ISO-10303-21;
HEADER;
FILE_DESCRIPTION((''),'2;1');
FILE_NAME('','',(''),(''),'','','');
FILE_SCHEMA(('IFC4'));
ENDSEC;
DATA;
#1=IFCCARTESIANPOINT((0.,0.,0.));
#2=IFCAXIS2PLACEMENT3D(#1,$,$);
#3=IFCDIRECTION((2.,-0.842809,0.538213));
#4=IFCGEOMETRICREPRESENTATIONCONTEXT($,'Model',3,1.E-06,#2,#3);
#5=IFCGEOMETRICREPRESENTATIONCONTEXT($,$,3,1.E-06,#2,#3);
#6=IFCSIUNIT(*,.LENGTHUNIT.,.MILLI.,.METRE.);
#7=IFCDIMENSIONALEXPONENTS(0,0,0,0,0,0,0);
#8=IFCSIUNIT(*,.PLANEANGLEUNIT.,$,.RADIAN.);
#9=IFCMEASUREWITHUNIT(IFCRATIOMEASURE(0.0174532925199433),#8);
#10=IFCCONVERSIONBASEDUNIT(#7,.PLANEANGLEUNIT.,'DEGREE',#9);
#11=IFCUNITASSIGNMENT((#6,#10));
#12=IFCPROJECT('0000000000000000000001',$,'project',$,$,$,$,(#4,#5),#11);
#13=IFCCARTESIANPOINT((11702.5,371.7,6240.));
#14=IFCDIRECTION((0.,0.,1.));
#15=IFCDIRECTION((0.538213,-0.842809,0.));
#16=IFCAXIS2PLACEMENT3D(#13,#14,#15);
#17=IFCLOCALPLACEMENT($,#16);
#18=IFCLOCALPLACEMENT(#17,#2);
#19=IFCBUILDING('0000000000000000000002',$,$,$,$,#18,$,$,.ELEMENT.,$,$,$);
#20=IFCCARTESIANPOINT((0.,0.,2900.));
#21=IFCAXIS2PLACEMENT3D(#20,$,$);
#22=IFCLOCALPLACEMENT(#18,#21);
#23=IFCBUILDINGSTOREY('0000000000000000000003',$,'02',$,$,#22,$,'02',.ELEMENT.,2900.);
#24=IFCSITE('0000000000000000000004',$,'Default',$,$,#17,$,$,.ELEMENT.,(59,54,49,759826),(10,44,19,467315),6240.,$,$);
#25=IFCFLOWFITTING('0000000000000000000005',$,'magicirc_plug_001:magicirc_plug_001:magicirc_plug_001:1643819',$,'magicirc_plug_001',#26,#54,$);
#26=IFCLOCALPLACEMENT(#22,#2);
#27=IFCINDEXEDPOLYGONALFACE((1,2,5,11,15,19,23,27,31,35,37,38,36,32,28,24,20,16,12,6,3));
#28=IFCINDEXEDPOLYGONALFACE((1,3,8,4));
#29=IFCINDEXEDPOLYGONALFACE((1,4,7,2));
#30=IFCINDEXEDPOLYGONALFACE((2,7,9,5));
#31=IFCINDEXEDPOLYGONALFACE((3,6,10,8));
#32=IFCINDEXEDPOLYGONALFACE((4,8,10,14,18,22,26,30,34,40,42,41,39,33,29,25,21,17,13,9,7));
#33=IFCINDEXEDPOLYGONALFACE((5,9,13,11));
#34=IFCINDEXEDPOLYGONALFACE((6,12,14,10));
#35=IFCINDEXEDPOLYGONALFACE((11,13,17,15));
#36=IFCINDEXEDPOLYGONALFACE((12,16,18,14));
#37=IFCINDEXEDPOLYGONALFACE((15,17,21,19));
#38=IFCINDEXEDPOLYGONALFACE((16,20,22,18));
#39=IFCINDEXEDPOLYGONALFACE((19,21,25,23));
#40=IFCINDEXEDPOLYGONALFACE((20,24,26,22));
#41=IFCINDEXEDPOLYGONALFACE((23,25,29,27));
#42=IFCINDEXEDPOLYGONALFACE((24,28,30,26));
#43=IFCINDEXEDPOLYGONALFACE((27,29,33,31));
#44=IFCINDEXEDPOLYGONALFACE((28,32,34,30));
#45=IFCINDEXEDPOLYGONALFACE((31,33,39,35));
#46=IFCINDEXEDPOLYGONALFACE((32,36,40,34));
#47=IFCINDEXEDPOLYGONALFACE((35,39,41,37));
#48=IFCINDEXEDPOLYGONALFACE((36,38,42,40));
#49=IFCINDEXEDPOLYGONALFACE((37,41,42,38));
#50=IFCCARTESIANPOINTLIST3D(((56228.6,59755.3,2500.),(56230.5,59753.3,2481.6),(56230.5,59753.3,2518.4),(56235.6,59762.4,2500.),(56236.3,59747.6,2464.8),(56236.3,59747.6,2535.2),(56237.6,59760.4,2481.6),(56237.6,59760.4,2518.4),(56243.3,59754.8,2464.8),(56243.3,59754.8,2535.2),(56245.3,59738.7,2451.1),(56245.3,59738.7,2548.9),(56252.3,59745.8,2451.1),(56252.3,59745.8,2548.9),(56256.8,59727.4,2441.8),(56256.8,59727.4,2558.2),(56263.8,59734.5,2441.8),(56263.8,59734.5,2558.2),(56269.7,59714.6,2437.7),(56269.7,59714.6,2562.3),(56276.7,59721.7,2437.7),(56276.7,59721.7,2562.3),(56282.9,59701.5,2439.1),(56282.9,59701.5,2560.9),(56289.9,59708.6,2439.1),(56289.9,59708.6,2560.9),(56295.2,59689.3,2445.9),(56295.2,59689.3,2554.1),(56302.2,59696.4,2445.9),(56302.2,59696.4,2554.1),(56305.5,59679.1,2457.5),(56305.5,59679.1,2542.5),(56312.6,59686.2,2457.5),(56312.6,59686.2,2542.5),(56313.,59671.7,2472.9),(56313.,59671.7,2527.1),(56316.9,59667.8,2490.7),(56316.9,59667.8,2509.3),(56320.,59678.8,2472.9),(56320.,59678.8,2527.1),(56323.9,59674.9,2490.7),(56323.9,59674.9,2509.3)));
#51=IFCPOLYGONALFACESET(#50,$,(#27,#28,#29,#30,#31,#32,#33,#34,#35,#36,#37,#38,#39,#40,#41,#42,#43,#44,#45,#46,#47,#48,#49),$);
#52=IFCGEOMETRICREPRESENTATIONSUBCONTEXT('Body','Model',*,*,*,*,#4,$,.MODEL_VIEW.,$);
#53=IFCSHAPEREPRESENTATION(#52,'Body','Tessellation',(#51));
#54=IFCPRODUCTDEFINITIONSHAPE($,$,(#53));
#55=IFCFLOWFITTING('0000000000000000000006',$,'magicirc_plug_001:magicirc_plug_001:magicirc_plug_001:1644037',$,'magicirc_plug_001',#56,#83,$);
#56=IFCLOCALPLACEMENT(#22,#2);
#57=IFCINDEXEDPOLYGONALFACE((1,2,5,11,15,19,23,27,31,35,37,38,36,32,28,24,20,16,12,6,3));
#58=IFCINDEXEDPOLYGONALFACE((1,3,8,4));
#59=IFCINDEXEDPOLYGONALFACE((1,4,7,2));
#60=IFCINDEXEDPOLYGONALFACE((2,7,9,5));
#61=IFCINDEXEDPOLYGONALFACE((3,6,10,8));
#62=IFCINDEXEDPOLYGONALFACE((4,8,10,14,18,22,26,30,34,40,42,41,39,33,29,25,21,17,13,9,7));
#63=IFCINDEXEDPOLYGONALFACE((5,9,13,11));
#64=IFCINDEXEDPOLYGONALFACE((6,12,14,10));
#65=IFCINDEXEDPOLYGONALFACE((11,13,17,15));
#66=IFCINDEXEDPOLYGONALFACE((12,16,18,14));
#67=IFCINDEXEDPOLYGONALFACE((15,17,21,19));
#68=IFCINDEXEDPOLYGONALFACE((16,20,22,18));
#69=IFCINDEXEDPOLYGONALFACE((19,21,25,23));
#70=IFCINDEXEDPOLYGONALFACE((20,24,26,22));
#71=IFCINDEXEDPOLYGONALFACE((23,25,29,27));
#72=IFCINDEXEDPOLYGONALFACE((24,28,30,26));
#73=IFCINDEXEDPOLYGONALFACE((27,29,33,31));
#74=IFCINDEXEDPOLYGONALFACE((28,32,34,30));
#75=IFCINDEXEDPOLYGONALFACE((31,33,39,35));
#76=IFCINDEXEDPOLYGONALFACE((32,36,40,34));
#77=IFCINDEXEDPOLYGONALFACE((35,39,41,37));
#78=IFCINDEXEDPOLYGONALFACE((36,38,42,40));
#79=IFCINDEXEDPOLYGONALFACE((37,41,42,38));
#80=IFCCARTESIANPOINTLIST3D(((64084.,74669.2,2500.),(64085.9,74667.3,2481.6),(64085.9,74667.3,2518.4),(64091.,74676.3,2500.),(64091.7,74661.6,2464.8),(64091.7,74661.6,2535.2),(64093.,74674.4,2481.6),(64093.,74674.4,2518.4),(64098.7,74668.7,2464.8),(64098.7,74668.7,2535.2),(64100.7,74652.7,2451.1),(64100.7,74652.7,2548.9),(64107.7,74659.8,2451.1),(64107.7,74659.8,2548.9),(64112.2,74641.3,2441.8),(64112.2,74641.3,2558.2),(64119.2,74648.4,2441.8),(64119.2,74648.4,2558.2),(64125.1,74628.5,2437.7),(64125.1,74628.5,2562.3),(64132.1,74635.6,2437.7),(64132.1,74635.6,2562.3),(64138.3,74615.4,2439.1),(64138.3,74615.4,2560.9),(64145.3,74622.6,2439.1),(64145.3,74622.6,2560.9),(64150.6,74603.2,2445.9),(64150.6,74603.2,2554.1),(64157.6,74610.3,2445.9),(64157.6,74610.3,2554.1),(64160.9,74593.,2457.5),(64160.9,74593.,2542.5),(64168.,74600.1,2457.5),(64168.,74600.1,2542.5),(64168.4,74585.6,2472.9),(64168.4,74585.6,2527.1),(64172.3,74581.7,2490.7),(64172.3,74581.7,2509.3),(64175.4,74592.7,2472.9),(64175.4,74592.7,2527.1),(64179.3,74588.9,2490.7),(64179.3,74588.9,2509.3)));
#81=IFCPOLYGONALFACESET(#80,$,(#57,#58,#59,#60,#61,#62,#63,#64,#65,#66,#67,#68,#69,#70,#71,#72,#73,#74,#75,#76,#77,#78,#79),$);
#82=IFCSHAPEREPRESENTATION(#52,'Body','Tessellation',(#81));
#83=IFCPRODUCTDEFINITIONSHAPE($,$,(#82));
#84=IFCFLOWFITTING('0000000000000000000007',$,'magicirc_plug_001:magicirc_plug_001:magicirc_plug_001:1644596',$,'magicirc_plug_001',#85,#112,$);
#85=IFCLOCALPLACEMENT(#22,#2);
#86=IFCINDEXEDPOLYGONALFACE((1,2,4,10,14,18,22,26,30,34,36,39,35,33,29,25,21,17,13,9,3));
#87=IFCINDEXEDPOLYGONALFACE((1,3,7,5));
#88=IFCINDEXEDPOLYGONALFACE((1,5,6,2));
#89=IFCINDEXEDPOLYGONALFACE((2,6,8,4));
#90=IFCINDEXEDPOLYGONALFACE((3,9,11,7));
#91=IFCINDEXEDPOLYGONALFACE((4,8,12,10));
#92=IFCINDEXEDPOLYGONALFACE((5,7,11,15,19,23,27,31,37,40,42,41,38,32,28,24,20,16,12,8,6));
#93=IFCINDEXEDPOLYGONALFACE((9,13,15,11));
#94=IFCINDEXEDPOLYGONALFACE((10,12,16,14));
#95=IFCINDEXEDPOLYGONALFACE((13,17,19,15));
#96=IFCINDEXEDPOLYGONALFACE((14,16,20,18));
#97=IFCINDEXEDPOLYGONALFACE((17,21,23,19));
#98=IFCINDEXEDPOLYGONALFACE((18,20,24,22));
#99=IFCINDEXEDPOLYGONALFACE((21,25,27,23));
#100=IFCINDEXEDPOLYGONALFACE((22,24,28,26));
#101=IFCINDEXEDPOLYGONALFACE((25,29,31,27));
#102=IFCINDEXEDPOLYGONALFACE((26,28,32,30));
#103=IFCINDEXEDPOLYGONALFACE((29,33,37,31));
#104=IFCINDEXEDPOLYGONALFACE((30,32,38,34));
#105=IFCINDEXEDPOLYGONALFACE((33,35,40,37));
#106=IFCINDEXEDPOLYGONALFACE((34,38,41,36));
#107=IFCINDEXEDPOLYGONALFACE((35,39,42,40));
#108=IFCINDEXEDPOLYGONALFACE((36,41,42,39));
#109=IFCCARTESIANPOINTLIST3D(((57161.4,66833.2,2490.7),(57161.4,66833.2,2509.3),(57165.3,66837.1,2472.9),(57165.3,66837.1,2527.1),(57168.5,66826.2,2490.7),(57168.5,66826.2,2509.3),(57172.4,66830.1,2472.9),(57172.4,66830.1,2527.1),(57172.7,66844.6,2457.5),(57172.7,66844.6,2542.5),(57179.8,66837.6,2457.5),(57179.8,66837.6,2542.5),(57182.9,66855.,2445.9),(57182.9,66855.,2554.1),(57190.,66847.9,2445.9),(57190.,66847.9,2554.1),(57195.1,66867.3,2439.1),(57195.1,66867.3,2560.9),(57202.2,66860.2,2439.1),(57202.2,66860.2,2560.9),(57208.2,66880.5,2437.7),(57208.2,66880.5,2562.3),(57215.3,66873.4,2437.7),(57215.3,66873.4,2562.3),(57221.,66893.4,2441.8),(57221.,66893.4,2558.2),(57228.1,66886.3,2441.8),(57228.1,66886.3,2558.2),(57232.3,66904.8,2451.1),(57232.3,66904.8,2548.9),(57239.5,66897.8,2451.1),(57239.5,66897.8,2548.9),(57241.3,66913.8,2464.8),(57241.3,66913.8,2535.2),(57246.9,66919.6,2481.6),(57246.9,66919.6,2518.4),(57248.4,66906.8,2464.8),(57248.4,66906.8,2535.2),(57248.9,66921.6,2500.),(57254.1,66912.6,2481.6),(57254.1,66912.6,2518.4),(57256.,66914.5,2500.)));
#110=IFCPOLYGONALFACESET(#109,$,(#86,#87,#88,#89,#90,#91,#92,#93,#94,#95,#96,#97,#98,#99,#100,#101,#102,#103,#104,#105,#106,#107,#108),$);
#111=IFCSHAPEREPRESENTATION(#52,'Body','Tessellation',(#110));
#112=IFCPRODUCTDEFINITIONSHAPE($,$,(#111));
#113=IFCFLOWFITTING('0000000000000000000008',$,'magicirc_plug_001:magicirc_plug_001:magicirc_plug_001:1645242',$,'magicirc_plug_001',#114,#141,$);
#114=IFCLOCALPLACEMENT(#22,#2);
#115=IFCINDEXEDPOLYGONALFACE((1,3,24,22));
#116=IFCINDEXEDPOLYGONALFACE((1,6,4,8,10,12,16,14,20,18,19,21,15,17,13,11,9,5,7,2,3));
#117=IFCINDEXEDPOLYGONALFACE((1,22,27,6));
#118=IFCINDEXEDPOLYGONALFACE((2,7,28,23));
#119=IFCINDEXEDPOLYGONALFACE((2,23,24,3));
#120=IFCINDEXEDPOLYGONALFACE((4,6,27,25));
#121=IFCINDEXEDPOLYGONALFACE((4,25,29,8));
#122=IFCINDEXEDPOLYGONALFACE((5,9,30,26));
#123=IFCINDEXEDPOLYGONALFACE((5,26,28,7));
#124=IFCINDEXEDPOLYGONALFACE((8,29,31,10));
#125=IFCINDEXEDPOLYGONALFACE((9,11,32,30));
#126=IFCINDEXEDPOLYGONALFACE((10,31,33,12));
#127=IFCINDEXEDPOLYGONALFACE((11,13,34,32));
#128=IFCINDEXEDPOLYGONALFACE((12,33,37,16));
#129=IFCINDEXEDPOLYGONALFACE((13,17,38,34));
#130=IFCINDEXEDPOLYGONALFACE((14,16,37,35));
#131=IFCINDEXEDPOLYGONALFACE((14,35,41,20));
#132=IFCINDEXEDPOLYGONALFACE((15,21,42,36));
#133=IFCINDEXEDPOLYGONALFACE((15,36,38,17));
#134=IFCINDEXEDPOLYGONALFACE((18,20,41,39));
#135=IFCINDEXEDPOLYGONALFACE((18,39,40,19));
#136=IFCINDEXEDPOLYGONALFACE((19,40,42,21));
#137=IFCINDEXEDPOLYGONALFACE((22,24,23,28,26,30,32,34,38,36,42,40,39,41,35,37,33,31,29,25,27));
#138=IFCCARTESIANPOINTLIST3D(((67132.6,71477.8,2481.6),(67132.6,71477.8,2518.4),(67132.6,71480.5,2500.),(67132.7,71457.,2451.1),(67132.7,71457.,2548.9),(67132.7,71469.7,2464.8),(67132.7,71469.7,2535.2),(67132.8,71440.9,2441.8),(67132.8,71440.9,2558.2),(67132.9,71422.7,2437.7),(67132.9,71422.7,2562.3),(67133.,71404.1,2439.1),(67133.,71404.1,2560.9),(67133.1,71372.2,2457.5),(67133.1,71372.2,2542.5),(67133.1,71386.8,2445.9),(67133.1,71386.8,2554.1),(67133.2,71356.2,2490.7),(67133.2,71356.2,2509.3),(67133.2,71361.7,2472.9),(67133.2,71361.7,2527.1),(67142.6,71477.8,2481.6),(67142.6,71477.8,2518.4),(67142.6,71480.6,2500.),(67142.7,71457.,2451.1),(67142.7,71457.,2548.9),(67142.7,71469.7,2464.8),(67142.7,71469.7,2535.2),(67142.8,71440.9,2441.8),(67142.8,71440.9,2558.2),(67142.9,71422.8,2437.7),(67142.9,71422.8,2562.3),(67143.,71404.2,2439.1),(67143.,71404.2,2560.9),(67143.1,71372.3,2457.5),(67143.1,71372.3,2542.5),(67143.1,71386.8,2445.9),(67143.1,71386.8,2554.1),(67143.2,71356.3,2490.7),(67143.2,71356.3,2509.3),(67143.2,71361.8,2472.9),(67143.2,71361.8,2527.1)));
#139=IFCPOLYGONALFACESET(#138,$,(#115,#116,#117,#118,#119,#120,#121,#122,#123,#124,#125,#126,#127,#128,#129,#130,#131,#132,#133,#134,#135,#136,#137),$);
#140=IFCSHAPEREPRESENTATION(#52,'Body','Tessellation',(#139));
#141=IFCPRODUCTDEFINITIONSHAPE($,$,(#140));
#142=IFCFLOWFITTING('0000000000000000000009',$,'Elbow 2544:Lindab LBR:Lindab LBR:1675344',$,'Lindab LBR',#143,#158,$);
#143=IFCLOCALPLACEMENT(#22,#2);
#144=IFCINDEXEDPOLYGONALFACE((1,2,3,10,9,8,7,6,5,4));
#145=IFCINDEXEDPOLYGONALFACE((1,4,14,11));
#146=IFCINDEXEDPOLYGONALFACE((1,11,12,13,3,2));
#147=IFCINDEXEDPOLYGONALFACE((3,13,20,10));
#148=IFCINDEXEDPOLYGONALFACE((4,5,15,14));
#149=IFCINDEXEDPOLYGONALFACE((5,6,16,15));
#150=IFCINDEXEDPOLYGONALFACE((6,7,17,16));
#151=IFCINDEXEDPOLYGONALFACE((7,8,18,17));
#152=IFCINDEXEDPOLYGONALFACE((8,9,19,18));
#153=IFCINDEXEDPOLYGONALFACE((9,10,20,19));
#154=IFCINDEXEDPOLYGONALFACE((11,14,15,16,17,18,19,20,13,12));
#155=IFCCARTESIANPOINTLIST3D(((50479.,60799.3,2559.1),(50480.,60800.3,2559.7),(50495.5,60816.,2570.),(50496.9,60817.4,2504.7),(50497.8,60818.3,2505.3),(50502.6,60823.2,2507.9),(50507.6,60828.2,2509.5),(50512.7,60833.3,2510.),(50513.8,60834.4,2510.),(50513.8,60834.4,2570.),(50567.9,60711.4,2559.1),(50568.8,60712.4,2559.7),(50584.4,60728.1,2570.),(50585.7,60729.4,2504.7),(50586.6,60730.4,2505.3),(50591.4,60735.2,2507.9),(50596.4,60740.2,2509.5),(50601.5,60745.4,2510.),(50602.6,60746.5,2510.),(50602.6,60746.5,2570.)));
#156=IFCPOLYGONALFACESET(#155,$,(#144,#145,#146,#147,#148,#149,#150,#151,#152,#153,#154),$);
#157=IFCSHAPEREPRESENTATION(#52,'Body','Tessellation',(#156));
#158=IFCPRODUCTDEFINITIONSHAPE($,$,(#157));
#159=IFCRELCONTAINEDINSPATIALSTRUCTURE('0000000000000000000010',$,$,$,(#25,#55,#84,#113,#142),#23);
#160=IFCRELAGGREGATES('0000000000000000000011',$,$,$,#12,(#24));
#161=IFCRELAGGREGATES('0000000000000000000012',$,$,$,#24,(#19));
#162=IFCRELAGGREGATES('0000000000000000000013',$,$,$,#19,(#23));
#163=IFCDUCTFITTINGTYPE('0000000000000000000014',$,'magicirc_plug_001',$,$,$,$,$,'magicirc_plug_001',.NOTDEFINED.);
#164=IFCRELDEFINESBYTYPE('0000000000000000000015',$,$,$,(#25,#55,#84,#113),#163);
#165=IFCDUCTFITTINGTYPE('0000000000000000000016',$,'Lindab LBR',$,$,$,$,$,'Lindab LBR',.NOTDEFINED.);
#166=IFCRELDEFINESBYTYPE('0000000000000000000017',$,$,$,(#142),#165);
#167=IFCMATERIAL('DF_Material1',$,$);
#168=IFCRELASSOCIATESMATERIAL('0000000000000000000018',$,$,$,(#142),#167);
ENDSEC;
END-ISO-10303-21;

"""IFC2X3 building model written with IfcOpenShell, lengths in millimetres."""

from ifc_helpers import new_model, entity, si_unit, converted_unit, direction, frame, frame_2d, origin, place, context, subcontext, project, spatial, polyline, circle_curve, parameter, trimmed, segment, composite_curve, circle, outline, extrude, source, transform, mapped, material, type_object, type_shapes, element, save


model = new_model("IFC2X3")

# Units and contexts
model_context = context("Model", 3, precision=1e-06, world=origin(), true_north=direction((2.0, -0.842809, 0.538213)))
context_of_model = context(None, 3, precision=1e-06, world=origin(), true_north=direction((2.0, -0.842809, 0.538213)))
body_context = subcontext(model_context, "Body", "Model", "MODEL_VIEW")
ifc_project = project(units=[si_unit("LENGTHUNIT", "METRE", prefix="MILLI"), converted_unit("PLANEANGLEUNIT", "DEGREE", entity("IfcRatioMeasure", 0.0174532925199433), si_unit("PLANEANGLEUNIT", "RADIAN"), dimensions=[0, 0, 0, 0, 0, 0, 0])], contexts=[model_context, context_of_model])

# Site, building, storey
site_placement = place(None, frame((11702.5, 371.7, 6240.0), z_axis=(0.0, 0.0, 1.0), x_axis=(0.538213, -0.842809, 0.0)))
site = spatial("IfcSite", under=ifc_project, at=site_placement, Name="Default", CompositionType="ELEMENT", RefLatitude=(59, 54, 49, 759826), RefLongitude=(10, 44, 19, 467315), RefElevation=6240.0)
building_placement = place(site_placement, origin())
building = spatial("IfcBuilding", under=site, at=building_placement, CompositionType="ELEMENT")
storey_placement = place(building_placement, frame((0.0, 0.0, 2900.0)))
storey = spatial("IfcBuildingStorey", under=building, at=storey_placement, Name="02", LongName="02", CompositionType="ELEMENT", Elevation=2900.0)

# Shared definitions
ifc_material = material(Name="DF_Material1")

# Flow fittings
duct_fitting_type_1 = type_object("IfcDuctFittingType", Name="magicirc_plug_001", ElementType="magicirc_plug_001", PredefinedType="NOTDEFINED")
shared_shape_1 = source(origin(), body_context, "Body", "SweptSolid", [
    extrude(circle(Radius=62.5, at=frame_2d((0.0, 0.0), x_axis=(1.0, 0.0))), frame((0.0, 0.0, 0.0), z_axis=(1.0, 0.0, 0.0), x_axis=(0.0, 1.0, 0.0)), (0.0, 0.0, 1.0), 10.0),
])
type_shapes(duct_fitting_type_1, [shared_shape_1])
for number, where, z_axis, x_axis, name in (
    (1, (56273.0, 59711.3, 2500.0), (0.0, 0.0, 1.0), (0.703643, 0.710554, 0.0), "magicirc_plug_001:magicirc_plug_001:magicirc_plug_001:1643819"),
    (2, (64128.4, 74625.2, 2500.0), (0.0, 0.0, 1.0), (0.703643, 0.710554, 0.0), "magicirc_plug_001:magicirc_plug_001:magicirc_plug_001:1644037"),
    (3, (57204.9, 66877.2, 2500.0), (0.0, 0.0, 1.0), (0.710554, -0.703643, 0.0), "magicirc_plug_001:magicirc_plug_001:magicirc_plug_001:1644596"),
    (4, (67132.9, 71418.0, 2500.0), (0.0, 0.0, 1.0), (0.999988, 0.004887, 0.0), "magicirc_plug_001:magicirc_plug_001:magicirc_plug_001:1645242"),
):
    element("IfcFlowFitting", number, at=place(storey_placement, frame(where, z_axis=z_axis, x_axis=x_axis)), inside=storey, type_object=duct_fitting_type_1, Name=name, ObjectType="magicirc_plug_001", context=body_context, shape_type="MappedRepresentation", body=[
        mapped(shared_shape_1, transform((0.0, 0.0, 0.0), scale=1.0)),
    ])
duct_fitting_type_2 = type_object("IfcDuctFittingType", Name="Lindab LBR", ElementType="Lindab LBR", PredefinedType="NOTDEFINED")
shared_shape_2 = source(origin(), body_context, "Body", "SweptSolid", [
    extrude(outline(composite_curve([segment(polyline([(1.2, -30.8), (2.6, -31.4)]), True, "CONTINUOUS"), segment(polyline([(2.6, -31.4), (27.9, 23.0)]), True, "CONTINUOUS"), segment(polyline([(27.9, 23.0), (26.6, 23.6)]), True, "CONTINUOUS"), segment(polyline([(26.6, 23.6), (4.5, 33.9)]), True, "CONTINUOUS"), segment(polyline([(4.5, 33.9), (-21.4, 33.9)]), True, "CONTINUOUS"), segment(polyline([(-21.4, 33.9), (-21.4, -26.1)]), True, "CONTINUOUS"), segment(polyline([(-21.4, -26.1), (-19.9, -26.1)]), True, "CONTINUOUS"), segment(trimmed(circle_curve(frame_2d((-19.9, -76.1), x_axis=(1.0, 0.0)), 50.0), [parameter(65.0)], [parameter(90.0)], True, "PARAMETER"), False, "CONTINUOUS")], self_intersect=False)), frame((2.2, 3.9, -62.5), z_axis=(0.0, 0.0, -1.0), x_axis=(1.0, 0.0, 0.0)), (0.0, 0.0, -1.0), 125.0),
])
type_shapes(duct_fitting_type_2, [shared_shape_2])
flow_fitting_placement = place(storey_placement, frame((50544.6, 60776.8, 2540.0), z_axis=(0.710554, -0.703643, 0.0), x_axis=(-0.703643, -0.710554, 0.0)))
element("IfcFlowFitting", 5, at=flow_fitting_placement, inside=storey, type_object=duct_fitting_type_2, material=ifc_material, Name="Elbow 2544:Lindab LBR:Lindab LBR:1675344", ObjectType="Lindab LBR", context=body_context, shape_type="MappedRepresentation", body=[
    mapped(shared_shape_2, transform((0.0, 0.0, 0.0), scale=1.0)),
])

save(model, "model.ifc")
